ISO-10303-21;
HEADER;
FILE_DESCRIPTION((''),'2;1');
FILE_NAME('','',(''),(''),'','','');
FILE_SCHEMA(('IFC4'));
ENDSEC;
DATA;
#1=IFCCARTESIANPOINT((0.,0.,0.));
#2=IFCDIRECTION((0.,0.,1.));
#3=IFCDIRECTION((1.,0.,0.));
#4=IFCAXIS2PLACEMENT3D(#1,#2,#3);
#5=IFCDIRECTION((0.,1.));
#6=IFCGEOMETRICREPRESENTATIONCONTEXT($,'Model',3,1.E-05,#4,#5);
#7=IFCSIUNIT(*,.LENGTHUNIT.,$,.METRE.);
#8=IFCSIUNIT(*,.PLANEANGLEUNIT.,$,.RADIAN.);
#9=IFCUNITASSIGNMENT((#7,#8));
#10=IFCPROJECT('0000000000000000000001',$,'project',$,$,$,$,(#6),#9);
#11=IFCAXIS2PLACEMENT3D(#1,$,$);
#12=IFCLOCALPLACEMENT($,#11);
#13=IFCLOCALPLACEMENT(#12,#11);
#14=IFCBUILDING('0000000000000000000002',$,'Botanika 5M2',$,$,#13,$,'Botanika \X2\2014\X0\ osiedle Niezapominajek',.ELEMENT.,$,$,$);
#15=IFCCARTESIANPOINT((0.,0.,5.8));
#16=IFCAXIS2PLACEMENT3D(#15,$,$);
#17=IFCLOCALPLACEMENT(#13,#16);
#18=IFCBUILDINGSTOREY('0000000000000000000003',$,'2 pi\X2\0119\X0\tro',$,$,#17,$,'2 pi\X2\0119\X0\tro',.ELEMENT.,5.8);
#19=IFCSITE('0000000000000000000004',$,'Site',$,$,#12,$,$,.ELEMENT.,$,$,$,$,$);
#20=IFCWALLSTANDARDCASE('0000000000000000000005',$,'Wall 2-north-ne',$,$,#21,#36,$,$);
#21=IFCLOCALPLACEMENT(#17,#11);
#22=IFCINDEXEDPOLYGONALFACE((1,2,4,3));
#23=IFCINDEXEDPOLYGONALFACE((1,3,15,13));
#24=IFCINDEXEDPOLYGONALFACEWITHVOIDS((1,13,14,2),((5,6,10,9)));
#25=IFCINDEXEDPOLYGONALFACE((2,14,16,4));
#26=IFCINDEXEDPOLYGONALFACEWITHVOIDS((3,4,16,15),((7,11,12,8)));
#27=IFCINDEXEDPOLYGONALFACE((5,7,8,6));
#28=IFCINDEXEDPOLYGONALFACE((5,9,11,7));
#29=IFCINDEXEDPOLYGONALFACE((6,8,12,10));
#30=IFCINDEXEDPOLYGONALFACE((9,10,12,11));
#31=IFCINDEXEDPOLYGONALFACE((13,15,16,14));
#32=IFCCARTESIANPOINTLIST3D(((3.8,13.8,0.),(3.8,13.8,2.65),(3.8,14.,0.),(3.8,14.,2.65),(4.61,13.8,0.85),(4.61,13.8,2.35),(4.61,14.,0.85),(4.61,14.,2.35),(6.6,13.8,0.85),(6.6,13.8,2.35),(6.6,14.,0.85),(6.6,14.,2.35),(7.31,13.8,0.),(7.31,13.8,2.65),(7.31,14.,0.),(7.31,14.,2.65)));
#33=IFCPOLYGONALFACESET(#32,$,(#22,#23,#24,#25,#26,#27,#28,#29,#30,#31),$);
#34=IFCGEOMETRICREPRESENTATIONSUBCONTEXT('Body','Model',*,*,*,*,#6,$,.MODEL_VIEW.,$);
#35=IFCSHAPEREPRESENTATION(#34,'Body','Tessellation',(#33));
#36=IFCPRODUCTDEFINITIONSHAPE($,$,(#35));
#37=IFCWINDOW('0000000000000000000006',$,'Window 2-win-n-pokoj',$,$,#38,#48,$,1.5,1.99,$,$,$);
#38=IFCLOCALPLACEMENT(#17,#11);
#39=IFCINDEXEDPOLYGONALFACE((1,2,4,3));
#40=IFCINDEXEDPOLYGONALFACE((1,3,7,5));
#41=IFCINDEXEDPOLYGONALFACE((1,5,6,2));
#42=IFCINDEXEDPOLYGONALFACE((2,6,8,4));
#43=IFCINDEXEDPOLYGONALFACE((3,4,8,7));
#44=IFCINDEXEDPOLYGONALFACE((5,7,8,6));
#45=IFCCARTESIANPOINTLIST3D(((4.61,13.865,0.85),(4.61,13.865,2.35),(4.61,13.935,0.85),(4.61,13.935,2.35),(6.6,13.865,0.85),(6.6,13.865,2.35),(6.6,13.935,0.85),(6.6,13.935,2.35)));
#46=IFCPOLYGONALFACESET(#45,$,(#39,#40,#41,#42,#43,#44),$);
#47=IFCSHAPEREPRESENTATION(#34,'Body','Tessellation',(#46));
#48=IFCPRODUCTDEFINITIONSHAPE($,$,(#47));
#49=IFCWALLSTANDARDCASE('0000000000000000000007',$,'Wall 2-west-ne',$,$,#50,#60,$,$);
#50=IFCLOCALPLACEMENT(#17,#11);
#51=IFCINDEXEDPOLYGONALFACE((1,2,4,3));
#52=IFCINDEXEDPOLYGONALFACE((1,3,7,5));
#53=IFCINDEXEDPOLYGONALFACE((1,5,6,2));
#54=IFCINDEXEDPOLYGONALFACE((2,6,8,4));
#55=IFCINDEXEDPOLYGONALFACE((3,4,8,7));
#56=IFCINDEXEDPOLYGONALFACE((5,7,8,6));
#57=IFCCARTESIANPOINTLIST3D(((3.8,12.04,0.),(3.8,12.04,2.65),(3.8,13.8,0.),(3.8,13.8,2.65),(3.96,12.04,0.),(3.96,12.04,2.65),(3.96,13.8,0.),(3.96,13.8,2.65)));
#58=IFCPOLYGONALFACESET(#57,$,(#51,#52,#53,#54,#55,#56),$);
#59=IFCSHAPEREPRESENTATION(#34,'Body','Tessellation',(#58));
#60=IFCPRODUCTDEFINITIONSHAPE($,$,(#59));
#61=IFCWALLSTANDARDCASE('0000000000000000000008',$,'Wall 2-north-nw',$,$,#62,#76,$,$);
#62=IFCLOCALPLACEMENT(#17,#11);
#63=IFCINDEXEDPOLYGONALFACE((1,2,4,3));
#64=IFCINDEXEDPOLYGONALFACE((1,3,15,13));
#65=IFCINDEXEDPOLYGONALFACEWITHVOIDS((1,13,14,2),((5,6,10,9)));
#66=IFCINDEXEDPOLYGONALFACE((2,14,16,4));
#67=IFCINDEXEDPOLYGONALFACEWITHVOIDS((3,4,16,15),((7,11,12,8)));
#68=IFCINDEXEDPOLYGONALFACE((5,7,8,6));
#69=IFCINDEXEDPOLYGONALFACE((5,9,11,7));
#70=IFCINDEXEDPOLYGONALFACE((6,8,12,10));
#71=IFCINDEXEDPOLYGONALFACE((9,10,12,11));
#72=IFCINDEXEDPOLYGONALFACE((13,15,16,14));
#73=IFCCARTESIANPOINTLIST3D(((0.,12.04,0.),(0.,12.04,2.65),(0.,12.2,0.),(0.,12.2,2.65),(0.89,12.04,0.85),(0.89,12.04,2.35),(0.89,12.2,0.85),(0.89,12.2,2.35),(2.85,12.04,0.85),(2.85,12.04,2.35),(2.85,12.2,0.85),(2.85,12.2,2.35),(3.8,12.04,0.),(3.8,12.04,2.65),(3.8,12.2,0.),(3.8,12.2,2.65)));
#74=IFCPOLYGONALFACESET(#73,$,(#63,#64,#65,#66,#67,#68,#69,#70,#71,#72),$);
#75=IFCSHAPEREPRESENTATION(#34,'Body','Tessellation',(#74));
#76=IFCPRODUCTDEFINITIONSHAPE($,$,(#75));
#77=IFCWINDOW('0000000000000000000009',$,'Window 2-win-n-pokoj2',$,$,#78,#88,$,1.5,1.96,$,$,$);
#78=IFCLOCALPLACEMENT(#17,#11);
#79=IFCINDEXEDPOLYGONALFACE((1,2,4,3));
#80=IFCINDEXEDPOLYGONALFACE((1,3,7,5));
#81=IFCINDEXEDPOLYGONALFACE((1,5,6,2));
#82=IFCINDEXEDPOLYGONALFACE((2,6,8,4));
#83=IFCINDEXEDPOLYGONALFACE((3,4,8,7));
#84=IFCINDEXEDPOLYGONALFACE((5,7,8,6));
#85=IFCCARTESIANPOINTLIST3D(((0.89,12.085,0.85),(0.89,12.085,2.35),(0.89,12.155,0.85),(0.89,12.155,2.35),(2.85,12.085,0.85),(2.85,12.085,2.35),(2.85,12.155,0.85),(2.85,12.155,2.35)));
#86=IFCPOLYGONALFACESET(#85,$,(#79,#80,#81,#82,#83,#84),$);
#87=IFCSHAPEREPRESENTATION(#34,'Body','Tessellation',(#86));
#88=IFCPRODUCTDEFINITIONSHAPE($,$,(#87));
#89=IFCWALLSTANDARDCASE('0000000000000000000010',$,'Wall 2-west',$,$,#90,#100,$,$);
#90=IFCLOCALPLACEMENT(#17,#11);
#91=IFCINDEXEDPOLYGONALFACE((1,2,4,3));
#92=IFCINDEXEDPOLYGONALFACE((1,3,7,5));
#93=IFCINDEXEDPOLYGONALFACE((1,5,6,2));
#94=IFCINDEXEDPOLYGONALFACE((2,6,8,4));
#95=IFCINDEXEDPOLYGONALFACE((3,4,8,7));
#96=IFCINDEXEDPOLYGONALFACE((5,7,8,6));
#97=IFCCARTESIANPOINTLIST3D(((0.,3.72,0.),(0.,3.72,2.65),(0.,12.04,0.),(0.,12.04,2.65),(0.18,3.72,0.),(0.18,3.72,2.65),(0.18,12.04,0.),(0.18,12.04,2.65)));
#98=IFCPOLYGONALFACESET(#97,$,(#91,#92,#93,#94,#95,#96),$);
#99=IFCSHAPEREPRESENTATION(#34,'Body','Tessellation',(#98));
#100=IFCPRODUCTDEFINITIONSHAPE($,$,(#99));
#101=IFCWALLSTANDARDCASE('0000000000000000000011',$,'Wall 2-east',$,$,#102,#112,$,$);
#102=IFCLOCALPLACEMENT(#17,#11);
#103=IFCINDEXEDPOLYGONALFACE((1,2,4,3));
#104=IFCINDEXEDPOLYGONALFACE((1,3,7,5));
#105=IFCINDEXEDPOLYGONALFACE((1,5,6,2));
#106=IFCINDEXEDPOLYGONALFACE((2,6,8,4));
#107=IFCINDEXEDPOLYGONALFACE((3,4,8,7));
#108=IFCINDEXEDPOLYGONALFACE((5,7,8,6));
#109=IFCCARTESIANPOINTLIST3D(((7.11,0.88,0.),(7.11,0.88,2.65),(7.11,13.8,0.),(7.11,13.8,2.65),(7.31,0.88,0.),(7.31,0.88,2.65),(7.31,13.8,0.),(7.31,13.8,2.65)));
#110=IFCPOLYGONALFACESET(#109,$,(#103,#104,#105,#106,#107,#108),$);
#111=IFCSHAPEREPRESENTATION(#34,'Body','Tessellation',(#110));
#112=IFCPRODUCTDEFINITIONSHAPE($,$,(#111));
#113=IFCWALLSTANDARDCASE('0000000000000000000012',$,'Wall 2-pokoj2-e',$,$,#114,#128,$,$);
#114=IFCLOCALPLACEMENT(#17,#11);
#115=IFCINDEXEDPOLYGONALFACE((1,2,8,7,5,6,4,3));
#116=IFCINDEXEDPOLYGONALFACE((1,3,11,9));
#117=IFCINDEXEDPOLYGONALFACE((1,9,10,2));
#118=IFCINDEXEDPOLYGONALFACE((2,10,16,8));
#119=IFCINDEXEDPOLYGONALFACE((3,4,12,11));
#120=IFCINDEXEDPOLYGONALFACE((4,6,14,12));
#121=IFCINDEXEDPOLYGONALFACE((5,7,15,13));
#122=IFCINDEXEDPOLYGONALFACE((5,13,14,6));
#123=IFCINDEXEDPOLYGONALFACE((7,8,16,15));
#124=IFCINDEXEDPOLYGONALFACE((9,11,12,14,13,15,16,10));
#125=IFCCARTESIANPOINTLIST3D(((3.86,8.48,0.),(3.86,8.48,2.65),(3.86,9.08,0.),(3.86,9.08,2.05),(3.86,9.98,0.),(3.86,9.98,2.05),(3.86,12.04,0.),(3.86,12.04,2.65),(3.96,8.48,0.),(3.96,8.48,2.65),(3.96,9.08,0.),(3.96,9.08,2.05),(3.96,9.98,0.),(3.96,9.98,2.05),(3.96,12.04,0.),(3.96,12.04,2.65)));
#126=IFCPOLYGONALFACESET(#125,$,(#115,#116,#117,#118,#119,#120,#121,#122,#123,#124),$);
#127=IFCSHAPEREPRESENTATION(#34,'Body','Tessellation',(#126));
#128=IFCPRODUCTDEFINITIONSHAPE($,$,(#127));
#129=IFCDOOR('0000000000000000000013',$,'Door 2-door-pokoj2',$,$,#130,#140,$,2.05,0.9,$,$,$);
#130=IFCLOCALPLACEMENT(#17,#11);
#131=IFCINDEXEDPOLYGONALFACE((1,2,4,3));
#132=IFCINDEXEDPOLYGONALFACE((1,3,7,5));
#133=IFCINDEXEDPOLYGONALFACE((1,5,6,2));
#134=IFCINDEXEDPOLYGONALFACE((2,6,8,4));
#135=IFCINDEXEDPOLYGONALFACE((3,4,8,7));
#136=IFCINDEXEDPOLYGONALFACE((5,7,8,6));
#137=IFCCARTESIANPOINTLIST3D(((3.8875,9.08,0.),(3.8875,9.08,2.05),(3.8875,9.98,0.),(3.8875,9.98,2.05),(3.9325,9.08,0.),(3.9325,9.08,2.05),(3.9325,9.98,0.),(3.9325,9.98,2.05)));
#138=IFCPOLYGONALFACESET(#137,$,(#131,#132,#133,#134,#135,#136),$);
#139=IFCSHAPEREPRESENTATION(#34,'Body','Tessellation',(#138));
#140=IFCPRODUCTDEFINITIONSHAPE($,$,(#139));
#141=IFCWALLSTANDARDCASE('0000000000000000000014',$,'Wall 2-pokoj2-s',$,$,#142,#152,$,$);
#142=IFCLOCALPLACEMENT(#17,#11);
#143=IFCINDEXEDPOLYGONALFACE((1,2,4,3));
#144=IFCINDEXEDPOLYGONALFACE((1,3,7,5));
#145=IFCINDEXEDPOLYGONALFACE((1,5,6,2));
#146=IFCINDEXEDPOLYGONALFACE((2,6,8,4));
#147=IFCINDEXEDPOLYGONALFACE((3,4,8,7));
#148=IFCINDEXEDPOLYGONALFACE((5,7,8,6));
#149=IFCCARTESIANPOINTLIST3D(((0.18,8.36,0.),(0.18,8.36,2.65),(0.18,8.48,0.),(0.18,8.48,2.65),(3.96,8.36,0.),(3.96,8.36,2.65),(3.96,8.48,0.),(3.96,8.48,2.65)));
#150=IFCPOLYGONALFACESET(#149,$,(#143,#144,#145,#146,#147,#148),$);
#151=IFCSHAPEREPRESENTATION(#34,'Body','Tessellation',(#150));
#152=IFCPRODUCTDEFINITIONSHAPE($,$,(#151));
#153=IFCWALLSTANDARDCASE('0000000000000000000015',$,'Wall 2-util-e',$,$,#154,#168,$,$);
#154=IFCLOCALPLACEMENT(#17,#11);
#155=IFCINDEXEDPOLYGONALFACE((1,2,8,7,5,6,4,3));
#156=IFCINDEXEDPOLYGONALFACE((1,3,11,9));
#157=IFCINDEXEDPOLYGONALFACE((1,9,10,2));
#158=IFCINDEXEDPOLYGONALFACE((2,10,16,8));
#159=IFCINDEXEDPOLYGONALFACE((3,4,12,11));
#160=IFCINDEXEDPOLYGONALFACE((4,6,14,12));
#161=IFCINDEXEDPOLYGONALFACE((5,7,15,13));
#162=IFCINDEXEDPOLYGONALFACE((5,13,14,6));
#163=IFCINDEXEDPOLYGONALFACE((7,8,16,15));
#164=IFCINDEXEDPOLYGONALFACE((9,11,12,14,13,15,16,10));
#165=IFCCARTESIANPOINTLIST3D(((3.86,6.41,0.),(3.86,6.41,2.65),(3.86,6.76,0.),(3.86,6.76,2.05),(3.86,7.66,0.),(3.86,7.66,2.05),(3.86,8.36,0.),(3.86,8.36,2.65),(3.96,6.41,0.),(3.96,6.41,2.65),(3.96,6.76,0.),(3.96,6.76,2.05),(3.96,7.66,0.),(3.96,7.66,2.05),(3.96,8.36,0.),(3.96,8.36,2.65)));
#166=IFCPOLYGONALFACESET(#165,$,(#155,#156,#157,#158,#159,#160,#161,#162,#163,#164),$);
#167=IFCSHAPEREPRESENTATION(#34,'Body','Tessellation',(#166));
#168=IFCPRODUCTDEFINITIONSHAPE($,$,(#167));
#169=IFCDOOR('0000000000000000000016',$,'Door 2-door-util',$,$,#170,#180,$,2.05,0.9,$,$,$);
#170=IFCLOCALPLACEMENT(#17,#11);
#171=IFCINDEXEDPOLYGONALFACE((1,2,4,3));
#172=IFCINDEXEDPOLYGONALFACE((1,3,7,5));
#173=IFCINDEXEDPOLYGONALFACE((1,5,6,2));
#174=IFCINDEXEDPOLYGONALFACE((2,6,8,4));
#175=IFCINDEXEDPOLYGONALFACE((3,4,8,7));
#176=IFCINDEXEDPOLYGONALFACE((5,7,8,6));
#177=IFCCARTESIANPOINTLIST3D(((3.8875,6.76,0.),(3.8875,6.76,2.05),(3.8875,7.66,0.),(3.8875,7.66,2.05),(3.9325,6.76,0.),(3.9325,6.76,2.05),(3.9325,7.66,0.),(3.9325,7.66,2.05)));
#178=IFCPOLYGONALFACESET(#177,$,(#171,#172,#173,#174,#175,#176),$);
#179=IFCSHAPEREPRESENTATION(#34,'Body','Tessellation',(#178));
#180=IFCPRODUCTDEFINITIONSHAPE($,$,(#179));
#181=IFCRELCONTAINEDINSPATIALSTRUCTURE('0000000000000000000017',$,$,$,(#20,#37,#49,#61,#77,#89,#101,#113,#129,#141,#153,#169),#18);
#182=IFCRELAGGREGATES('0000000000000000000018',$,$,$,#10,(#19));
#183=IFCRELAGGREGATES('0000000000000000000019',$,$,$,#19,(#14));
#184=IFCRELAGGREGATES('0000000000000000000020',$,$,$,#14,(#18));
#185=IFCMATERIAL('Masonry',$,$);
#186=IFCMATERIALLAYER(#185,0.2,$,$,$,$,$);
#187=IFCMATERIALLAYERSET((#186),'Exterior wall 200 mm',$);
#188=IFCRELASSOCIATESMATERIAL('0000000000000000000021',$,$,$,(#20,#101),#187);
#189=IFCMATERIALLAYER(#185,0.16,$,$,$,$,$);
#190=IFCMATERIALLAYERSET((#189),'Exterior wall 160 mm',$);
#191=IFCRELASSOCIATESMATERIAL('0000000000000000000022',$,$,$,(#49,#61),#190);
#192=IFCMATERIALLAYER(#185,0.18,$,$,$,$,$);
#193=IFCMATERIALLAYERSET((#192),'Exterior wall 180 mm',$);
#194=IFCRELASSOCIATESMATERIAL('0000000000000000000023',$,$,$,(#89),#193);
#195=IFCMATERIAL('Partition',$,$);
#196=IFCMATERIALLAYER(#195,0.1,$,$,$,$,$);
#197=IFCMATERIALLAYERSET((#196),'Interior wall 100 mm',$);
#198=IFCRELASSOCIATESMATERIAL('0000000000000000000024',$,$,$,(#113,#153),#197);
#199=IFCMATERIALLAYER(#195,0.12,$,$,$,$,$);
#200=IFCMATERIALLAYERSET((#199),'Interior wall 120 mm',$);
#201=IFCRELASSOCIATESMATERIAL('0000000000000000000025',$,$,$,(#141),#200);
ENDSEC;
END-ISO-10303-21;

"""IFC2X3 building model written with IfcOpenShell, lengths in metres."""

from ifc_helpers import new_model, si_unit, direction, frame, frame_2d, origin, origin_with_axes, place, context, subcontext, project, spatial, rectangle, extrude, material, layer, layer_set, layer_usage, element, fill, save


model = new_model("IFC2X3")

# Units and contexts
model_context = context("Model", 3, precision=1e-05, world=origin_with_axes(), true_north=direction((0.0, 1.0)))
body_context = subcontext(model_context, "Body", "Model", "MODEL_VIEW")
ifc_project = project(units=[si_unit("LENGTHUNIT", "METRE"), si_unit("PLANEANGLEUNIT", "RADIAN")], contexts=[model_context])

# Site, building, storey
site_placement = place(None, origin())
site = spatial("IfcSite", under=ifc_project, at=site_placement, Name="Site", CompositionType="ELEMENT")
building_placement = place(site_placement, origin())
building = spatial("IfcBuilding", under=site, at=building_placement, Name="Botanika 5M2", LongName="Botanika — osiedle Niezapominajek", CompositionType="ELEMENT")
storey_placement = place(building_placement, frame((0.0, 0.0, 5.8)))
storey = spatial("IfcBuildingStorey", under=building, at=storey_placement, Name="2 piętro", LongName="2 piętro", CompositionType="ELEMENT", Elevation=5.8)

# Wall, opening, window
ifc_material_1 = material(Name="Masonry")
ifc_layer_1 = layer(ifc_material_1, 0.2)
ifc_layer_set_1 = layer_set([ifc_layer_1], Name="Exterior wall 200 mm")
ifc_layer_usage_1 = layer_usage(ifc_layer_set_1, "AXIS2", "POSITIVE", -0.1)
wall_1_placement = place(storey_placement, frame((3.8, 13.9, 0.0)))
wall_1 = element("IfcWallStandardCase", 1, at=wall_1_placement, inside=storey, material=ifc_layer_usage_1, Name="Wall 2-north-ne", context=body_context, shape_type="SweptSolid", body=[
    extrude(rectangle(XDim=3.51, YDim=0.2, at=frame_2d((1.755, 0.0))), origin_with_axes(), (0.0, 0.0, 1.0), 2.65),
])
opening_1_placement = place(wall_1_placement, frame((0.81, 0.15, 0.85), z_axis=(0.0, -1.0, 0.0), x_axis=(1.0, 0.0, 0.0)))
opening_1 = element("IfcOpeningElement", 2, at=opening_1_placement, cuts=wall_1, context=body_context, shape_type="SweptSolid", body=[
    extrude(rectangle(XDim=1.99, YDim=1.5, at=frame_2d((0.995, 0.75))), origin_with_axes(), (0.0, 0.0, 1.0), 0.3),
])
window_1_placement = place(wall_1_placement, frame((0.81, 0.0, 0.85)))
window_1 = element("IfcWindow", 3, at=window_1_placement, inside=storey, Name="Window 2-win-n-pokoj", OverallHeight=1.5, OverallWidth=1.99, context=body_context, shape_type="SweptSolid", body=[
    extrude(rectangle(XDim=1.99, YDim=0.07, at=frame_2d((0.995, 0.0))), origin_with_axes(), (0.0, 0.0, 1.0), 1.5),
])
fill(opening_1, window_1)

# Wall
ifc_layer_2 = layer(ifc_material_1, 0.16)
ifc_layer_set_2 = layer_set([ifc_layer_2], Name="Exterior wall 160 mm")
ifc_layer_usage_2 = layer_usage(ifc_layer_set_2, "AXIS2", "POSITIVE", -0.08)
wall_2_placement = place(storey_placement, frame((3.88, 13.8, 0.0), z_axis=(0.0, 0.0, 1.0), x_axis=(0.0, -1.0, 0.0)))
element("IfcWallStandardCase", 4, at=wall_2_placement, inside=storey, material=ifc_layer_usage_2, Name="Wall 2-west-ne", context=body_context, shape_type="SweptSolid", body=[
    extrude(rectangle(XDim=1.76, YDim=0.16, at=frame_2d((0.88, 0.0))), origin_with_axes(), (0.0, 0.0, 1.0), 2.65),
])

# Wall, opening, window
wall_3_placement = place(storey_placement, frame((0.0, 12.12, 0.0)))
wall_3 = element("IfcWallStandardCase", 5, at=wall_3_placement, inside=storey, material=ifc_layer_usage_2, Name="Wall 2-north-nw", context=body_context, shape_type="SweptSolid", body=[
    extrude(rectangle(XDim=3.8, YDim=0.16, at=frame_2d((1.9, 0.0))), origin_with_axes(), (0.0, 0.0, 1.0), 2.65),
])
opening_2_placement = place(wall_3_placement, frame((0.89, 0.13, 0.85), z_axis=(0.0, -1.0, 0.0), x_axis=(1.0, 0.0, 0.0)))
opening_2 = element("IfcOpeningElement", 6, at=opening_2_placement, cuts=wall_3, context=body_context, shape_type="SweptSolid", body=[
    extrude(rectangle(XDim=1.96, YDim=1.5, at=frame_2d((0.98, 0.75))), origin_with_axes(), (0.0, 0.0, 1.0), 0.26),
])
window_2_placement = place(wall_3_placement, frame((0.89, 0.0, 0.85)))
window_2 = element("IfcWindow", 7, at=window_2_placement, inside=storey, Name="Window 2-win-n-pokoj2", OverallHeight=1.5, OverallWidth=1.96, context=body_context, shape_type="SweptSolid", body=[
    extrude(rectangle(XDim=1.96, YDim=0.07, at=frame_2d((0.98, 0.0))), origin_with_axes(), (0.0, 0.0, 1.0), 1.5),
])
fill(opening_2, window_2)

# Walls
ifc_layer_3 = layer(ifc_material_1, 0.18)
ifc_layer_set_3 = layer_set([ifc_layer_3], Name="Exterior wall 180 mm")
ifc_layer_usage_3 = layer_usage(ifc_layer_set_3, "AXIS2", "POSITIVE", -0.09)
wall_4_placement = place(storey_placement, frame((0.09, 12.04, 0.0), z_axis=(0.0, 0.0, 1.0), x_axis=(0.0, -1.0, 0.0)))
element("IfcWallStandardCase", 8, at=wall_4_placement, inside=storey, material=ifc_layer_usage_3, Name="Wall 2-west", context=body_context, shape_type="SweptSolid", body=[
    extrude(rectangle(XDim=8.32, YDim=0.18, at=frame_2d((4.16, 0.0))), origin_with_axes(), (0.0, 0.0, 1.0), 2.65),
])
wall_5_placement = place(storey_placement, frame((7.21, 13.8, 0.0), z_axis=(0.0, 0.0, 1.0), x_axis=(0.0, -1.0, 0.0)))
element("IfcWallStandardCase", 9, at=wall_5_placement, inside=storey, material=ifc_layer_usage_1, Name="Wall 2-east", context=body_context, shape_type="SweptSolid", body=[
    extrude(rectangle(XDim=12.92, YDim=0.2, at=frame_2d((6.46, 0.0))), origin_with_axes(), (0.0, 0.0, 1.0), 2.65),
])

# Wall, opening, door
ifc_material_2 = material(Name="Partition")
ifc_layer_4 = layer(ifc_material_2, 0.1)
ifc_layer_set_4 = layer_set([ifc_layer_4], Name="Interior wall 100 mm")
ifc_layer_usage_4 = layer_usage(ifc_layer_set_4, "AXIS2", "POSITIVE", -0.05)
wall_6_placement = place(storey_placement, frame((3.91, 12.04, 0.0), z_axis=(0.0, 0.0, 1.0), x_axis=(0.0, -1.0, 0.0)))
wall_6 = element("IfcWallStandardCase", 10, at=wall_6_placement, inside=storey, material=ifc_layer_usage_4, Name="Wall 2-pokoj2-e", context=body_context, shape_type="SweptSolid", body=[
    extrude(rectangle(XDim=3.56, YDim=0.1, at=frame_2d((1.78, 0.0))), origin_with_axes(), (0.0, 0.0, 1.0), 2.65),
])
opening_3_placement = place(wall_6_placement, frame((2.06, 0.1, 0.0), z_axis=(0.0, -1.0, 0.0), x_axis=(1.0, 0.0, 0.0)))
opening_3 = element("IfcOpeningElement", 11, at=opening_3_placement, cuts=wall_6, context=body_context, shape_type="SweptSolid", body=[
    extrude(rectangle(XDim=0.9, YDim=2.05, at=frame_2d((0.45, 1.025))), origin_with_axes(), (0.0, 0.0, 1.0), 0.2),
])
door_1_placement = place(wall_6_placement, frame((2.06, 0.0, 0.0)))
door_1 = element("IfcDoor", 12, at=door_1_placement, inside=storey, Name="Door 2-door-pokoj2", OverallHeight=2.05, OverallWidth=0.9, context=body_context, shape_type="SweptSolid", body=[
    extrude(rectangle(XDim=0.9, YDim=0.045, at=frame_2d((0.45, 0.0))), origin_with_axes(), (0.0, 0.0, 1.0), 2.05),
])
fill(opening_3, door_1)

# Wall
ifc_layer_5 = layer(ifc_material_2, 0.12)
ifc_layer_set_5 = layer_set([ifc_layer_5], Name="Interior wall 120 mm")
ifc_layer_usage_5 = layer_usage(ifc_layer_set_5, "AXIS2", "POSITIVE", -0.06)
wall_7_placement = place(storey_placement, frame((0.18, 8.42, 0.0)))
element("IfcWallStandardCase", 13, at=wall_7_placement, inside=storey, material=ifc_layer_usage_5, Name="Wall 2-pokoj2-s", context=body_context, shape_type="SweptSolid", body=[
    extrude(rectangle(XDim=3.78, YDim=0.12, at=frame_2d((1.89, 0.0))), origin_with_axes(), (0.0, 0.0, 1.0), 2.65),
])

# Wall, opening, door
wall_8_placement = place(storey_placement, frame((3.91, 8.36, 0.0), z_axis=(0.0, 0.0, 1.0), x_axis=(0.0, -1.0, 0.0)))
wall_8 = element("IfcWallStandardCase", 14, at=wall_8_placement, inside=storey, material=ifc_layer_usage_4, Name="Wall 2-util-e", context=body_context, shape_type="SweptSolid", body=[
    extrude(rectangle(XDim=1.95, YDim=0.1, at=frame_2d((0.975, 0.0))), origin_with_axes(), (0.0, 0.0, 1.0), 2.65),
])
opening_4_placement = place(wall_8_placement, frame((0.7, 0.1, 0.0), z_axis=(0.0, -1.0, 0.0), x_axis=(1.0, 0.0, 0.0)))
opening_4 = element("IfcOpeningElement", 15, at=opening_4_placement, cuts=wall_8, context=body_context, shape_type="SweptSolid", body=[
    extrude(rectangle(XDim=0.9, YDim=2.05, at=frame_2d((0.45, 1.025))), origin_with_axes(), (0.0, 0.0, 1.0), 0.2),
])
door_2_placement = place(wall_8_placement, frame((0.7, 0.0, 0.0)))
door_2 = element("IfcDoor", 16, at=door_2_placement, inside=storey, Name="Door 2-door-util", OverallHeight=2.05, OverallWidth=0.9, context=body_context, shape_type="SweptSolid", body=[
    extrude(rectangle(XDim=0.9, YDim=0.045, at=frame_2d((0.45, 0.0))), origin_with_axes(), (0.0, 0.0, 1.0), 2.05),
])
fill(opening_4, door_2)

save(model, "model.ifc")
